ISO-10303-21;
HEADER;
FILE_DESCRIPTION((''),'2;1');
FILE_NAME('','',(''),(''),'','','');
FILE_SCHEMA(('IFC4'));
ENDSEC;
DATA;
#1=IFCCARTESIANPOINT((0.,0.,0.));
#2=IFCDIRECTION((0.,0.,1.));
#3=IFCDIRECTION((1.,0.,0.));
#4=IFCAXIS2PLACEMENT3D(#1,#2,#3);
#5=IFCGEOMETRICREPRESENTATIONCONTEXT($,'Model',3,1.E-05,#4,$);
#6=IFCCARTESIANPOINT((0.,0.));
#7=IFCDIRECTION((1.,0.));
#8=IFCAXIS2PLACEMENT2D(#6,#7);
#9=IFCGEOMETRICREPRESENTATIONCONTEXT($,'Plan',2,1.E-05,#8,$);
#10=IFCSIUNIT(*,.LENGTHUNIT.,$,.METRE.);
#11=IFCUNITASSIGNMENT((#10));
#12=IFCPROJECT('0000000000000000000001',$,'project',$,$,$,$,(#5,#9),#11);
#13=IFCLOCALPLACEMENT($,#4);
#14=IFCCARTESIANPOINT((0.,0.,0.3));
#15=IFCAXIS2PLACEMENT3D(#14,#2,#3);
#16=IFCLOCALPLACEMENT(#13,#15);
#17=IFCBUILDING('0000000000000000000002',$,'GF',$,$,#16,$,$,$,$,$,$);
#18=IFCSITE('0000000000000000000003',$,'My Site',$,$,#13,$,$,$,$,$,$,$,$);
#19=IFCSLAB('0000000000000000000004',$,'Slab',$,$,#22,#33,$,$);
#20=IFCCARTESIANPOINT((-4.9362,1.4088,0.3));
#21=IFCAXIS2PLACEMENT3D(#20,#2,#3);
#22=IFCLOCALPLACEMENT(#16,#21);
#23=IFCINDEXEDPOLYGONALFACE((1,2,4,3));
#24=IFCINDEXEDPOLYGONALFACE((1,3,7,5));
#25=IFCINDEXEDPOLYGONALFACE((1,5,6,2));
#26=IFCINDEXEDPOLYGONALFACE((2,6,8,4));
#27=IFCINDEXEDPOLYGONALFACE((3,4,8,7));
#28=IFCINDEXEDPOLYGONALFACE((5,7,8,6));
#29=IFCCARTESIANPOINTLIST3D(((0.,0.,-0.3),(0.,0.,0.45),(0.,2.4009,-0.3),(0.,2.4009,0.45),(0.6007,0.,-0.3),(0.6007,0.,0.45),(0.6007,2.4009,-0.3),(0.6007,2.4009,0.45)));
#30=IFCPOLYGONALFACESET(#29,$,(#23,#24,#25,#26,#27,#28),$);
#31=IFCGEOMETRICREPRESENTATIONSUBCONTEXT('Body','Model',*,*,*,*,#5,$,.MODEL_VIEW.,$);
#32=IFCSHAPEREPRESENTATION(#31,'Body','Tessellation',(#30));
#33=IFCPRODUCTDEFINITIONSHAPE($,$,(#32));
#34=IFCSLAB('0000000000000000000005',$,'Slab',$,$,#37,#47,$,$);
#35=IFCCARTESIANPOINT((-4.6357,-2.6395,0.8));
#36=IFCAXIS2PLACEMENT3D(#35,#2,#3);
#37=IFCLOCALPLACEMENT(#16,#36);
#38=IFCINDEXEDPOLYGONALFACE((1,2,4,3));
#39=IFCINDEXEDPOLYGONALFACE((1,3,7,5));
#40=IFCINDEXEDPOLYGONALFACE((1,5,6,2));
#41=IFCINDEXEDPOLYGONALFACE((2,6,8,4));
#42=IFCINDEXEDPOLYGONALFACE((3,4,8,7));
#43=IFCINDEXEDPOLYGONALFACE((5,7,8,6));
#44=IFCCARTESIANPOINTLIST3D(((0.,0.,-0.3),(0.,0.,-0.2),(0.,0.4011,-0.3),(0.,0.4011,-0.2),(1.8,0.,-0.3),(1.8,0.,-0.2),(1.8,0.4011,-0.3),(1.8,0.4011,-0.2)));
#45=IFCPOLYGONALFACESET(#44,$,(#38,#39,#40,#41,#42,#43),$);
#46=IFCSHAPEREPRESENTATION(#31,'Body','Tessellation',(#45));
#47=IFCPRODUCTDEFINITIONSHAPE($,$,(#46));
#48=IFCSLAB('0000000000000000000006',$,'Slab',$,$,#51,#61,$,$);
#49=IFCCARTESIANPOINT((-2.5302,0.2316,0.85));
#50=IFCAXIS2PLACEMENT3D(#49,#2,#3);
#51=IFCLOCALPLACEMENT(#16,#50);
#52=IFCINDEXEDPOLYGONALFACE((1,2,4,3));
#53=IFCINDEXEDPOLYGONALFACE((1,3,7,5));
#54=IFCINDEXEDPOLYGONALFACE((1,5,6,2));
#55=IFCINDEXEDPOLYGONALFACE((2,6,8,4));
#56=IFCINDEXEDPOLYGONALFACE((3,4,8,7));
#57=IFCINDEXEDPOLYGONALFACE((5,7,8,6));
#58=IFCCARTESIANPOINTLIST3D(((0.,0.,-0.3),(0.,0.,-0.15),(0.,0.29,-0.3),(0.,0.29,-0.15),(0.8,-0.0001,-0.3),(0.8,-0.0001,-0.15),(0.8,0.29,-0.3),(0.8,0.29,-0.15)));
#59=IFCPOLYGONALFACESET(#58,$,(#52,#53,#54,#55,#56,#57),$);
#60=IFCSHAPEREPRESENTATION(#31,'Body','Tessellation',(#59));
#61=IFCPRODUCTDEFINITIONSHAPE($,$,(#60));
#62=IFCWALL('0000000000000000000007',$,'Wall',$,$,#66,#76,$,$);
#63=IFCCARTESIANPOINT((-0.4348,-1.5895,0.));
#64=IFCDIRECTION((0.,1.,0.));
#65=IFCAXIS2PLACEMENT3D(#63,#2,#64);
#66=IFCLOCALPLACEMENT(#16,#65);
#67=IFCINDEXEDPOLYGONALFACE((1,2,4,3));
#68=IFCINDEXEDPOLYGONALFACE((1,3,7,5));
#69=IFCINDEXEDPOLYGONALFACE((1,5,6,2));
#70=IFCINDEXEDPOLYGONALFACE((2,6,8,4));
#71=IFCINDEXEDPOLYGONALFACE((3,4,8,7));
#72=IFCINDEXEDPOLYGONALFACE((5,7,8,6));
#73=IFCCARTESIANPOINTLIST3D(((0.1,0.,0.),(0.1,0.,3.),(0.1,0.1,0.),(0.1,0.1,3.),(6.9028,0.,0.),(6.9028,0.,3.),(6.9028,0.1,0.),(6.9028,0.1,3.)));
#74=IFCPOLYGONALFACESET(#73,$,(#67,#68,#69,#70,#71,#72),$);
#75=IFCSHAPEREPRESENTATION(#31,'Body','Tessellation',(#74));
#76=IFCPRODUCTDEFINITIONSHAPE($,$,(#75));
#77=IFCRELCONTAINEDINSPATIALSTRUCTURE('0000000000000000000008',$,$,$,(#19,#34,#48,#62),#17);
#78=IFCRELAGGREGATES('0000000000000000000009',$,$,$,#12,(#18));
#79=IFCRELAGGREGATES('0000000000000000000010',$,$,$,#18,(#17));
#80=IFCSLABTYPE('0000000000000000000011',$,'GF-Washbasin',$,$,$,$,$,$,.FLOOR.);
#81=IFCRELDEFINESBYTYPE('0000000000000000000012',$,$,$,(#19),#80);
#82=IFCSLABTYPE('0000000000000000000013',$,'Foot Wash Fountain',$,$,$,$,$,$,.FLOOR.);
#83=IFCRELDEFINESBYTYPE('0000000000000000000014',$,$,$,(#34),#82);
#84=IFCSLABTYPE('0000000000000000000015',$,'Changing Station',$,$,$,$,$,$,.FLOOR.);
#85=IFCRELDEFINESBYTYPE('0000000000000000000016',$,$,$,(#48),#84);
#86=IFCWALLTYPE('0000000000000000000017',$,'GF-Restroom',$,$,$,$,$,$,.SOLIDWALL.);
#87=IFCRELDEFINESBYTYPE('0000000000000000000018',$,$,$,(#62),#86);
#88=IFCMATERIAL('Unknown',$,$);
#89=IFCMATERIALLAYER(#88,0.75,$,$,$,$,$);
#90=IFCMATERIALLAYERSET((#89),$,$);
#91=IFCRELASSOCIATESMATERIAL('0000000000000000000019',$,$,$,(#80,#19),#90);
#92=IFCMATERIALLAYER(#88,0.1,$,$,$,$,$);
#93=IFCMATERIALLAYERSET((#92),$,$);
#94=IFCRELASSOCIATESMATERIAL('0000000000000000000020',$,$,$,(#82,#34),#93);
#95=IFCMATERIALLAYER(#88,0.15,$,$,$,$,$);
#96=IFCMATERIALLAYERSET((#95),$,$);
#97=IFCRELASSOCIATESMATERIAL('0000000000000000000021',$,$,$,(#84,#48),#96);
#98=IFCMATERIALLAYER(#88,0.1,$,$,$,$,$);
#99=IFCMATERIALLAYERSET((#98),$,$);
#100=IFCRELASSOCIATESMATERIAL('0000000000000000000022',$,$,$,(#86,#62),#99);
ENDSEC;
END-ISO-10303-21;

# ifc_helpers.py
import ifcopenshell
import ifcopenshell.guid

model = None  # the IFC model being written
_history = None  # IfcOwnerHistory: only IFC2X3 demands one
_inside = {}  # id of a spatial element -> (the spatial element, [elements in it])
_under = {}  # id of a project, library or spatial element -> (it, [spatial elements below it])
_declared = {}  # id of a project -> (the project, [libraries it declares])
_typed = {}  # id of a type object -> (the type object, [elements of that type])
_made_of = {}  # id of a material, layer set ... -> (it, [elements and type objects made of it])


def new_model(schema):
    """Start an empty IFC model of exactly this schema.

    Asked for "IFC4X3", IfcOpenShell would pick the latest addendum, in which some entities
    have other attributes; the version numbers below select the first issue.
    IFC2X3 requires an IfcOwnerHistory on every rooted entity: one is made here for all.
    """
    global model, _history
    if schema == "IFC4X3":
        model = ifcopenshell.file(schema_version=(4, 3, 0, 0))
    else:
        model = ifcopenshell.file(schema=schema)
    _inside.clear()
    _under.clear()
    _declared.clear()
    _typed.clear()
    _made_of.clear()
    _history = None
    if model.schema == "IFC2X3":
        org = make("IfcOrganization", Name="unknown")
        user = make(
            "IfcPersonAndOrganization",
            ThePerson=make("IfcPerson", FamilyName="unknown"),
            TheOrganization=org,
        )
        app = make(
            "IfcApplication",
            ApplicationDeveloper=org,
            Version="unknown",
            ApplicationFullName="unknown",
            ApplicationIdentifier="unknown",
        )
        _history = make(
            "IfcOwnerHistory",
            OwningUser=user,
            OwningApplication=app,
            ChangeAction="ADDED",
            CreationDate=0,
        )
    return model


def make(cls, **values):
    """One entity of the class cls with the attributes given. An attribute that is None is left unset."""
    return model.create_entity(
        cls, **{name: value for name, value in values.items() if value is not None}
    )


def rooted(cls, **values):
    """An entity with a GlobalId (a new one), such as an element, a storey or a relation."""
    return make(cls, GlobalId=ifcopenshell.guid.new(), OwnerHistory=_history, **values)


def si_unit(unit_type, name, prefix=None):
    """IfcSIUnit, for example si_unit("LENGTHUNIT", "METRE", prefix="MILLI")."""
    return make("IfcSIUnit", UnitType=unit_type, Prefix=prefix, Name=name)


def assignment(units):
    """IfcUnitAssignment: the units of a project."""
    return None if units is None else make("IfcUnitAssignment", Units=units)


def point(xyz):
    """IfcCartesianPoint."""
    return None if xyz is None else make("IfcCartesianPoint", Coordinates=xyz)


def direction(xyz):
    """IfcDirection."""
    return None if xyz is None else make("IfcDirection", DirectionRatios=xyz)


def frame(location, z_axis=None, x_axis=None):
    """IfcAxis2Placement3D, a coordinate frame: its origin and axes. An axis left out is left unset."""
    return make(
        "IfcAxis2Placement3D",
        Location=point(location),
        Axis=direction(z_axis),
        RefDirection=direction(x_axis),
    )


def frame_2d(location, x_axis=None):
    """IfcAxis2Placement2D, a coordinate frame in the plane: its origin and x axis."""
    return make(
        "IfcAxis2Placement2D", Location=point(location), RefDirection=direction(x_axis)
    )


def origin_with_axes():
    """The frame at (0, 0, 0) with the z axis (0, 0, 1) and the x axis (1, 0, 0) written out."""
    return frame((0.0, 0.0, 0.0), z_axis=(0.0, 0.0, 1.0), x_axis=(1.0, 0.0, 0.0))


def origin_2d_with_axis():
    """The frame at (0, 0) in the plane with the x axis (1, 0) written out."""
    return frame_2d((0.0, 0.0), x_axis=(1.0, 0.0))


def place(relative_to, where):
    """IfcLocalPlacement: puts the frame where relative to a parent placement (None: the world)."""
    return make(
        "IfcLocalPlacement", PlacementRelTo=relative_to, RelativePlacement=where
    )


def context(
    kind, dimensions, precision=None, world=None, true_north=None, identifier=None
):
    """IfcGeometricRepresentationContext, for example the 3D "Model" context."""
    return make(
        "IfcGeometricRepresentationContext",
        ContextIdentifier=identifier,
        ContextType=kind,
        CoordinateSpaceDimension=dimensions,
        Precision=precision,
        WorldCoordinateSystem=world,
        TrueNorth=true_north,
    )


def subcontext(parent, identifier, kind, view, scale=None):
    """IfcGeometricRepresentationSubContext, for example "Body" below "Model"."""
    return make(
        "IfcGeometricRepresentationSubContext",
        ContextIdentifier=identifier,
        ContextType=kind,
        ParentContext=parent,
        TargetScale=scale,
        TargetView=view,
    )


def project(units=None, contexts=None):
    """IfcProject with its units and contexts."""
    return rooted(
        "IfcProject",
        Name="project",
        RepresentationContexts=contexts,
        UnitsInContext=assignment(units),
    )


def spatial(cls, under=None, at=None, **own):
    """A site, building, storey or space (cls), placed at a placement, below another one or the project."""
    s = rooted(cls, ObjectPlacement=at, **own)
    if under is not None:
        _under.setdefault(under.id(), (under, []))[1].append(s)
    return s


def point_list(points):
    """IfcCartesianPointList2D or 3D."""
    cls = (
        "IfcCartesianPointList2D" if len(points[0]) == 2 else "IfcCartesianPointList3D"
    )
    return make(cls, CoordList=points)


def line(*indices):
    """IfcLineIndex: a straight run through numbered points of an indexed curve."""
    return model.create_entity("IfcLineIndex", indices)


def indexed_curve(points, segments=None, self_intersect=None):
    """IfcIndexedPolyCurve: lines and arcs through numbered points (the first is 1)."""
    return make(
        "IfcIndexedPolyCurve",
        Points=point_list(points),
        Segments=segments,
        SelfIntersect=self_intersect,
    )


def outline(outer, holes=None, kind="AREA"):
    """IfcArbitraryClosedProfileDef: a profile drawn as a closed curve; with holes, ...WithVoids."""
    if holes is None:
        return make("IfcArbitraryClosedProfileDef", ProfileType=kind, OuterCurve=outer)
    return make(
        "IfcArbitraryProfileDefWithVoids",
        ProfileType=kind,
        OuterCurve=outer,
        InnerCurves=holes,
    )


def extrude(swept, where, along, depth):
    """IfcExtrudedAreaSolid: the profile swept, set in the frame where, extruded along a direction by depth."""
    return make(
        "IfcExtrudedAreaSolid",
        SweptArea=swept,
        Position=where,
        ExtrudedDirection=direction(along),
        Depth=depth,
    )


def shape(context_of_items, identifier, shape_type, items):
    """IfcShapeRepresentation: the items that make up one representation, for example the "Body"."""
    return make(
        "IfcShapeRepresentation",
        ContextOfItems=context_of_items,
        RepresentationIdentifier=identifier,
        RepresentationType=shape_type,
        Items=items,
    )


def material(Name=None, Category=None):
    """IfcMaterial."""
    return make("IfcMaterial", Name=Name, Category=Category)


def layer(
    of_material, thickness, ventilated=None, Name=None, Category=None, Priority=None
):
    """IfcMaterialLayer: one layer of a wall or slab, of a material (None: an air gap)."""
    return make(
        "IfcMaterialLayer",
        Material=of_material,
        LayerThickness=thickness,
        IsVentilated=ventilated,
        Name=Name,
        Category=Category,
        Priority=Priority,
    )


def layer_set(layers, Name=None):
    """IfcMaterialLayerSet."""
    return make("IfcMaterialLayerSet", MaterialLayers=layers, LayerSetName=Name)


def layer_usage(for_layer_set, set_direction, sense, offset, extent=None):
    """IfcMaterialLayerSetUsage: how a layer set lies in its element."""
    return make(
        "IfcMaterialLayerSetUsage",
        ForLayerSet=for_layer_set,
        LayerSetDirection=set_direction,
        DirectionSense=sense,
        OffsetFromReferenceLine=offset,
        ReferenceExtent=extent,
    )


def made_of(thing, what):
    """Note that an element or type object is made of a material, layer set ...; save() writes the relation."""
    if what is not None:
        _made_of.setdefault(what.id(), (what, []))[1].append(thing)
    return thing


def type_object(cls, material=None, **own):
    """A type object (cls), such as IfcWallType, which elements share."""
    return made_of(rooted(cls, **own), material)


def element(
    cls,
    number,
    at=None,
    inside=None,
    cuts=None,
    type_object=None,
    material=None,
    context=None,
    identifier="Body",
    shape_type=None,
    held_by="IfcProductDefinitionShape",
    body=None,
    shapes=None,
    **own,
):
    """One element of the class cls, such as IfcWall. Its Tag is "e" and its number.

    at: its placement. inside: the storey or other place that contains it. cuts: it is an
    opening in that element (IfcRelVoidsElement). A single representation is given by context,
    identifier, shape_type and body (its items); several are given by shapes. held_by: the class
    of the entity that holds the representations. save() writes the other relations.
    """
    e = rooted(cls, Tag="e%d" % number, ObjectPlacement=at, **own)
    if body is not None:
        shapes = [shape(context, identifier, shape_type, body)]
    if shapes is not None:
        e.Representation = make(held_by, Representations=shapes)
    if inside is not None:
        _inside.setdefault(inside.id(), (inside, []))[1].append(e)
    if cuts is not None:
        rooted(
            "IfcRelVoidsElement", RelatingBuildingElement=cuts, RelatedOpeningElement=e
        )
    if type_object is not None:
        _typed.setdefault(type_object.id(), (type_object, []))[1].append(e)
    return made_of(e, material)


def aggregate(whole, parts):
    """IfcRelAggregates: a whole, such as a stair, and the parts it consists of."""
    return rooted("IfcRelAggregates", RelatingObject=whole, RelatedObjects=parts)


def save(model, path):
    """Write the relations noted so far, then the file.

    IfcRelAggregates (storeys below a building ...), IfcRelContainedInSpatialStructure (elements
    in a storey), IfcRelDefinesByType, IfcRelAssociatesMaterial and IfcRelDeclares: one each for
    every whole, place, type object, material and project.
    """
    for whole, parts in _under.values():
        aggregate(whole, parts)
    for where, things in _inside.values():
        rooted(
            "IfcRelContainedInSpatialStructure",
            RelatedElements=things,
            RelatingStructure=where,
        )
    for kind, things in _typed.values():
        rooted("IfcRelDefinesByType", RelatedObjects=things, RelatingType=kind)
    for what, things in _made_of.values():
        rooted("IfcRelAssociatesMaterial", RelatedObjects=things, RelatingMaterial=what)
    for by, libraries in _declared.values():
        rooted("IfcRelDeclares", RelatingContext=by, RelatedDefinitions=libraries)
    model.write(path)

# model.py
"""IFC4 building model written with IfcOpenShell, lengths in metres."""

from ifc_helpers import new_model, si_unit, frame, origin_with_axes, origin_2d_with_axis, place, context, subcontext, project, spatial, line, indexed_curve, outline, extrude, material, layer, layer_set, layer_usage, type_object, element, save


model = new_model("IFC4")

# Units and contexts
model_context = context("Model", 3, precision=1e-05, world=origin_with_axes())
plan_context = context("Plan", 2, precision=1e-05, world=origin_2d_with_axis())
body_context_1 = subcontext(model_context, "Body", "Model", "MODEL_VIEW")
ifc_project = project(units=[si_unit("LENGTHUNIT", "METRE")], contexts=[model_context, plan_context])

# Site, building
site_placement = place(None, origin_with_axes())
site = spatial("IfcSite", under=ifc_project, at=site_placement, Name="My Site")
building_placement = place(site_placement, frame((0.0, 0.0, 0.3), z_axis=(0.0, 0.0, 1.0), x_axis=(1.0, 0.0, 0.0)))
building = spatial("IfcBuilding", under=site, at=building_placement, Name="GF")

# Shared definitions
ifc_material = material(Name="Unknown")

# Slabs
ifc_layer_1 = layer(ifc_material, 0.75)
ifc_layer_set_1 = layer_set([ifc_layer_1])
ifc_layer_usage_1 = layer_usage(ifc_layer_set_1, "AXIS3", "POSITIVE", -0.3)
slab_type_1 = type_object("IfcSlabType", Name="GF-Washbasin", PredefinedType="FLOOR", material=ifc_layer_set_1)
slab_1_placement = place(building_placement, frame((-4.9362, 1.4088, 0.3), z_axis=(0.0, 0.0, 1.0), x_axis=(1.0, 0.0, 0.0)))
element("IfcSlab", 1, at=slab_1_placement, inside=building, type_object=slab_type_1, material=ifc_layer_usage_1, Name="Slab", context=body_context_1, shape_type="SweptSolid", body=[
    extrude(outline(indexed_curve([(0.0, 0.0), (0.6007, 0.0), (0.6007, 2.4009), (0.0, 2.4009), (0.0, 0.0)])), frame((0.0, 0.0, -0.3), z_axis=(0.0, 0.0, 1.0), x_axis=(1.0, 0.0, 0.0)), (0.0, 0.0, 1.0), 0.75),
])
ifc_layer_2 = layer(ifc_material, 0.1)
ifc_layer_set_2 = layer_set([ifc_layer_2])
ifc_layer_usage_2 = layer_usage(ifc_layer_set_2, "AXIS3", "POSITIVE", -0.3)
slab_type_2 = type_object("IfcSlabType", Name="Foot Wash Fountain", PredefinedType="FLOOR", material=ifc_layer_set_2)
slab_2_placement = place(building_placement, frame((-4.6357, -2.6395, 0.8), z_axis=(0.0, 0.0, 1.0), x_axis=(1.0, 0.0, 0.0)))
element("IfcSlab", 2, at=slab_2_placement, inside=building, type_object=slab_type_2, material=ifc_layer_usage_2, Name="Slab", context=body_context_1, shape_type="SweptSolid", body=[
    extrude(outline(indexed_curve([(0.0, 0.0), (0.0, 0.4011), (1.8, 0.4011), (1.8, 0.0), (0.0, 0.0)])), frame((0.0, 0.0, -0.3), z_axis=(0.0, 0.0, 1.0), x_axis=(1.0, 0.0, 0.0)), (0.0, 0.0, 1.0), 0.1),
])
ifc_layer_3 = layer(ifc_material, 0.15)
ifc_layer_set_3 = layer_set([ifc_layer_3])
ifc_layer_usage_3 = layer_usage(ifc_layer_set_3, "AXIS3", "POSITIVE", -0.3)
slab_type_3 = type_object("IfcSlabType", Name="Changing Station", PredefinedType="FLOOR", material=ifc_layer_set_3)
slab_3_placement = place(building_placement, frame((-2.5302, 0.2316, 0.85), z_axis=(0.0, 0.0, 1.0), x_axis=(1.0, 0.0, 0.0)))
element("IfcSlab", 3, at=slab_3_placement, inside=building, type_object=slab_type_3, material=ifc_layer_usage_3, Name="Slab", context=body_context_1, shape_type="SweptSolid", body=[
    extrude(outline(indexed_curve([(0.0, 0.0), (0.0, 0.29), (0.8, 0.29), (0.8, -0.0001), (0.0, 0.0)])), frame((0.0, 0.0, -0.3), z_axis=(0.0, 0.0, 1.0), x_axis=(1.0, 0.0, 0.0)), (0.0, 0.0, 1.0), 0.15),
])

# Wall
ifc_layer_4 = layer(ifc_material, 0.1)
ifc_layer_set_4 = layer_set([ifc_layer_4])
wall_type_1 = type_object("IfcWallType", Name="GF-Restroom", PredefinedType="SOLIDWALL", material=ifc_layer_set_4)
ifc_layer_usage_4 = layer_usage(ifc_layer_set_4, "AXIS2", "POSITIVE", 0.0)
wall_1_placement = place(building_placement, frame((-0.4348, -1.5895, 0.0), z_axis=(0.0, 0.0, 1.0), x_axis=(0.0, 1.0, 0.0)))
element("IfcWall", 4, at=wall_1_placement, inside=building, type_object=wall_type_1, material=ifc_layer_usage_4, Name="Wall", context=body_context_1, shape_type="SweptSolid", body=[
    extrude(outline(indexed_curve([(0.1, 0.0), (0.1, 0.1), (6.9028, 0.1), (6.9028, 0.0)], segments=[line(1, 2, 3, 4, 1)])), origin_with_axes(), (0.0, 0.0, 1.0), 3.0),
])

save(model, "model.ifc")
